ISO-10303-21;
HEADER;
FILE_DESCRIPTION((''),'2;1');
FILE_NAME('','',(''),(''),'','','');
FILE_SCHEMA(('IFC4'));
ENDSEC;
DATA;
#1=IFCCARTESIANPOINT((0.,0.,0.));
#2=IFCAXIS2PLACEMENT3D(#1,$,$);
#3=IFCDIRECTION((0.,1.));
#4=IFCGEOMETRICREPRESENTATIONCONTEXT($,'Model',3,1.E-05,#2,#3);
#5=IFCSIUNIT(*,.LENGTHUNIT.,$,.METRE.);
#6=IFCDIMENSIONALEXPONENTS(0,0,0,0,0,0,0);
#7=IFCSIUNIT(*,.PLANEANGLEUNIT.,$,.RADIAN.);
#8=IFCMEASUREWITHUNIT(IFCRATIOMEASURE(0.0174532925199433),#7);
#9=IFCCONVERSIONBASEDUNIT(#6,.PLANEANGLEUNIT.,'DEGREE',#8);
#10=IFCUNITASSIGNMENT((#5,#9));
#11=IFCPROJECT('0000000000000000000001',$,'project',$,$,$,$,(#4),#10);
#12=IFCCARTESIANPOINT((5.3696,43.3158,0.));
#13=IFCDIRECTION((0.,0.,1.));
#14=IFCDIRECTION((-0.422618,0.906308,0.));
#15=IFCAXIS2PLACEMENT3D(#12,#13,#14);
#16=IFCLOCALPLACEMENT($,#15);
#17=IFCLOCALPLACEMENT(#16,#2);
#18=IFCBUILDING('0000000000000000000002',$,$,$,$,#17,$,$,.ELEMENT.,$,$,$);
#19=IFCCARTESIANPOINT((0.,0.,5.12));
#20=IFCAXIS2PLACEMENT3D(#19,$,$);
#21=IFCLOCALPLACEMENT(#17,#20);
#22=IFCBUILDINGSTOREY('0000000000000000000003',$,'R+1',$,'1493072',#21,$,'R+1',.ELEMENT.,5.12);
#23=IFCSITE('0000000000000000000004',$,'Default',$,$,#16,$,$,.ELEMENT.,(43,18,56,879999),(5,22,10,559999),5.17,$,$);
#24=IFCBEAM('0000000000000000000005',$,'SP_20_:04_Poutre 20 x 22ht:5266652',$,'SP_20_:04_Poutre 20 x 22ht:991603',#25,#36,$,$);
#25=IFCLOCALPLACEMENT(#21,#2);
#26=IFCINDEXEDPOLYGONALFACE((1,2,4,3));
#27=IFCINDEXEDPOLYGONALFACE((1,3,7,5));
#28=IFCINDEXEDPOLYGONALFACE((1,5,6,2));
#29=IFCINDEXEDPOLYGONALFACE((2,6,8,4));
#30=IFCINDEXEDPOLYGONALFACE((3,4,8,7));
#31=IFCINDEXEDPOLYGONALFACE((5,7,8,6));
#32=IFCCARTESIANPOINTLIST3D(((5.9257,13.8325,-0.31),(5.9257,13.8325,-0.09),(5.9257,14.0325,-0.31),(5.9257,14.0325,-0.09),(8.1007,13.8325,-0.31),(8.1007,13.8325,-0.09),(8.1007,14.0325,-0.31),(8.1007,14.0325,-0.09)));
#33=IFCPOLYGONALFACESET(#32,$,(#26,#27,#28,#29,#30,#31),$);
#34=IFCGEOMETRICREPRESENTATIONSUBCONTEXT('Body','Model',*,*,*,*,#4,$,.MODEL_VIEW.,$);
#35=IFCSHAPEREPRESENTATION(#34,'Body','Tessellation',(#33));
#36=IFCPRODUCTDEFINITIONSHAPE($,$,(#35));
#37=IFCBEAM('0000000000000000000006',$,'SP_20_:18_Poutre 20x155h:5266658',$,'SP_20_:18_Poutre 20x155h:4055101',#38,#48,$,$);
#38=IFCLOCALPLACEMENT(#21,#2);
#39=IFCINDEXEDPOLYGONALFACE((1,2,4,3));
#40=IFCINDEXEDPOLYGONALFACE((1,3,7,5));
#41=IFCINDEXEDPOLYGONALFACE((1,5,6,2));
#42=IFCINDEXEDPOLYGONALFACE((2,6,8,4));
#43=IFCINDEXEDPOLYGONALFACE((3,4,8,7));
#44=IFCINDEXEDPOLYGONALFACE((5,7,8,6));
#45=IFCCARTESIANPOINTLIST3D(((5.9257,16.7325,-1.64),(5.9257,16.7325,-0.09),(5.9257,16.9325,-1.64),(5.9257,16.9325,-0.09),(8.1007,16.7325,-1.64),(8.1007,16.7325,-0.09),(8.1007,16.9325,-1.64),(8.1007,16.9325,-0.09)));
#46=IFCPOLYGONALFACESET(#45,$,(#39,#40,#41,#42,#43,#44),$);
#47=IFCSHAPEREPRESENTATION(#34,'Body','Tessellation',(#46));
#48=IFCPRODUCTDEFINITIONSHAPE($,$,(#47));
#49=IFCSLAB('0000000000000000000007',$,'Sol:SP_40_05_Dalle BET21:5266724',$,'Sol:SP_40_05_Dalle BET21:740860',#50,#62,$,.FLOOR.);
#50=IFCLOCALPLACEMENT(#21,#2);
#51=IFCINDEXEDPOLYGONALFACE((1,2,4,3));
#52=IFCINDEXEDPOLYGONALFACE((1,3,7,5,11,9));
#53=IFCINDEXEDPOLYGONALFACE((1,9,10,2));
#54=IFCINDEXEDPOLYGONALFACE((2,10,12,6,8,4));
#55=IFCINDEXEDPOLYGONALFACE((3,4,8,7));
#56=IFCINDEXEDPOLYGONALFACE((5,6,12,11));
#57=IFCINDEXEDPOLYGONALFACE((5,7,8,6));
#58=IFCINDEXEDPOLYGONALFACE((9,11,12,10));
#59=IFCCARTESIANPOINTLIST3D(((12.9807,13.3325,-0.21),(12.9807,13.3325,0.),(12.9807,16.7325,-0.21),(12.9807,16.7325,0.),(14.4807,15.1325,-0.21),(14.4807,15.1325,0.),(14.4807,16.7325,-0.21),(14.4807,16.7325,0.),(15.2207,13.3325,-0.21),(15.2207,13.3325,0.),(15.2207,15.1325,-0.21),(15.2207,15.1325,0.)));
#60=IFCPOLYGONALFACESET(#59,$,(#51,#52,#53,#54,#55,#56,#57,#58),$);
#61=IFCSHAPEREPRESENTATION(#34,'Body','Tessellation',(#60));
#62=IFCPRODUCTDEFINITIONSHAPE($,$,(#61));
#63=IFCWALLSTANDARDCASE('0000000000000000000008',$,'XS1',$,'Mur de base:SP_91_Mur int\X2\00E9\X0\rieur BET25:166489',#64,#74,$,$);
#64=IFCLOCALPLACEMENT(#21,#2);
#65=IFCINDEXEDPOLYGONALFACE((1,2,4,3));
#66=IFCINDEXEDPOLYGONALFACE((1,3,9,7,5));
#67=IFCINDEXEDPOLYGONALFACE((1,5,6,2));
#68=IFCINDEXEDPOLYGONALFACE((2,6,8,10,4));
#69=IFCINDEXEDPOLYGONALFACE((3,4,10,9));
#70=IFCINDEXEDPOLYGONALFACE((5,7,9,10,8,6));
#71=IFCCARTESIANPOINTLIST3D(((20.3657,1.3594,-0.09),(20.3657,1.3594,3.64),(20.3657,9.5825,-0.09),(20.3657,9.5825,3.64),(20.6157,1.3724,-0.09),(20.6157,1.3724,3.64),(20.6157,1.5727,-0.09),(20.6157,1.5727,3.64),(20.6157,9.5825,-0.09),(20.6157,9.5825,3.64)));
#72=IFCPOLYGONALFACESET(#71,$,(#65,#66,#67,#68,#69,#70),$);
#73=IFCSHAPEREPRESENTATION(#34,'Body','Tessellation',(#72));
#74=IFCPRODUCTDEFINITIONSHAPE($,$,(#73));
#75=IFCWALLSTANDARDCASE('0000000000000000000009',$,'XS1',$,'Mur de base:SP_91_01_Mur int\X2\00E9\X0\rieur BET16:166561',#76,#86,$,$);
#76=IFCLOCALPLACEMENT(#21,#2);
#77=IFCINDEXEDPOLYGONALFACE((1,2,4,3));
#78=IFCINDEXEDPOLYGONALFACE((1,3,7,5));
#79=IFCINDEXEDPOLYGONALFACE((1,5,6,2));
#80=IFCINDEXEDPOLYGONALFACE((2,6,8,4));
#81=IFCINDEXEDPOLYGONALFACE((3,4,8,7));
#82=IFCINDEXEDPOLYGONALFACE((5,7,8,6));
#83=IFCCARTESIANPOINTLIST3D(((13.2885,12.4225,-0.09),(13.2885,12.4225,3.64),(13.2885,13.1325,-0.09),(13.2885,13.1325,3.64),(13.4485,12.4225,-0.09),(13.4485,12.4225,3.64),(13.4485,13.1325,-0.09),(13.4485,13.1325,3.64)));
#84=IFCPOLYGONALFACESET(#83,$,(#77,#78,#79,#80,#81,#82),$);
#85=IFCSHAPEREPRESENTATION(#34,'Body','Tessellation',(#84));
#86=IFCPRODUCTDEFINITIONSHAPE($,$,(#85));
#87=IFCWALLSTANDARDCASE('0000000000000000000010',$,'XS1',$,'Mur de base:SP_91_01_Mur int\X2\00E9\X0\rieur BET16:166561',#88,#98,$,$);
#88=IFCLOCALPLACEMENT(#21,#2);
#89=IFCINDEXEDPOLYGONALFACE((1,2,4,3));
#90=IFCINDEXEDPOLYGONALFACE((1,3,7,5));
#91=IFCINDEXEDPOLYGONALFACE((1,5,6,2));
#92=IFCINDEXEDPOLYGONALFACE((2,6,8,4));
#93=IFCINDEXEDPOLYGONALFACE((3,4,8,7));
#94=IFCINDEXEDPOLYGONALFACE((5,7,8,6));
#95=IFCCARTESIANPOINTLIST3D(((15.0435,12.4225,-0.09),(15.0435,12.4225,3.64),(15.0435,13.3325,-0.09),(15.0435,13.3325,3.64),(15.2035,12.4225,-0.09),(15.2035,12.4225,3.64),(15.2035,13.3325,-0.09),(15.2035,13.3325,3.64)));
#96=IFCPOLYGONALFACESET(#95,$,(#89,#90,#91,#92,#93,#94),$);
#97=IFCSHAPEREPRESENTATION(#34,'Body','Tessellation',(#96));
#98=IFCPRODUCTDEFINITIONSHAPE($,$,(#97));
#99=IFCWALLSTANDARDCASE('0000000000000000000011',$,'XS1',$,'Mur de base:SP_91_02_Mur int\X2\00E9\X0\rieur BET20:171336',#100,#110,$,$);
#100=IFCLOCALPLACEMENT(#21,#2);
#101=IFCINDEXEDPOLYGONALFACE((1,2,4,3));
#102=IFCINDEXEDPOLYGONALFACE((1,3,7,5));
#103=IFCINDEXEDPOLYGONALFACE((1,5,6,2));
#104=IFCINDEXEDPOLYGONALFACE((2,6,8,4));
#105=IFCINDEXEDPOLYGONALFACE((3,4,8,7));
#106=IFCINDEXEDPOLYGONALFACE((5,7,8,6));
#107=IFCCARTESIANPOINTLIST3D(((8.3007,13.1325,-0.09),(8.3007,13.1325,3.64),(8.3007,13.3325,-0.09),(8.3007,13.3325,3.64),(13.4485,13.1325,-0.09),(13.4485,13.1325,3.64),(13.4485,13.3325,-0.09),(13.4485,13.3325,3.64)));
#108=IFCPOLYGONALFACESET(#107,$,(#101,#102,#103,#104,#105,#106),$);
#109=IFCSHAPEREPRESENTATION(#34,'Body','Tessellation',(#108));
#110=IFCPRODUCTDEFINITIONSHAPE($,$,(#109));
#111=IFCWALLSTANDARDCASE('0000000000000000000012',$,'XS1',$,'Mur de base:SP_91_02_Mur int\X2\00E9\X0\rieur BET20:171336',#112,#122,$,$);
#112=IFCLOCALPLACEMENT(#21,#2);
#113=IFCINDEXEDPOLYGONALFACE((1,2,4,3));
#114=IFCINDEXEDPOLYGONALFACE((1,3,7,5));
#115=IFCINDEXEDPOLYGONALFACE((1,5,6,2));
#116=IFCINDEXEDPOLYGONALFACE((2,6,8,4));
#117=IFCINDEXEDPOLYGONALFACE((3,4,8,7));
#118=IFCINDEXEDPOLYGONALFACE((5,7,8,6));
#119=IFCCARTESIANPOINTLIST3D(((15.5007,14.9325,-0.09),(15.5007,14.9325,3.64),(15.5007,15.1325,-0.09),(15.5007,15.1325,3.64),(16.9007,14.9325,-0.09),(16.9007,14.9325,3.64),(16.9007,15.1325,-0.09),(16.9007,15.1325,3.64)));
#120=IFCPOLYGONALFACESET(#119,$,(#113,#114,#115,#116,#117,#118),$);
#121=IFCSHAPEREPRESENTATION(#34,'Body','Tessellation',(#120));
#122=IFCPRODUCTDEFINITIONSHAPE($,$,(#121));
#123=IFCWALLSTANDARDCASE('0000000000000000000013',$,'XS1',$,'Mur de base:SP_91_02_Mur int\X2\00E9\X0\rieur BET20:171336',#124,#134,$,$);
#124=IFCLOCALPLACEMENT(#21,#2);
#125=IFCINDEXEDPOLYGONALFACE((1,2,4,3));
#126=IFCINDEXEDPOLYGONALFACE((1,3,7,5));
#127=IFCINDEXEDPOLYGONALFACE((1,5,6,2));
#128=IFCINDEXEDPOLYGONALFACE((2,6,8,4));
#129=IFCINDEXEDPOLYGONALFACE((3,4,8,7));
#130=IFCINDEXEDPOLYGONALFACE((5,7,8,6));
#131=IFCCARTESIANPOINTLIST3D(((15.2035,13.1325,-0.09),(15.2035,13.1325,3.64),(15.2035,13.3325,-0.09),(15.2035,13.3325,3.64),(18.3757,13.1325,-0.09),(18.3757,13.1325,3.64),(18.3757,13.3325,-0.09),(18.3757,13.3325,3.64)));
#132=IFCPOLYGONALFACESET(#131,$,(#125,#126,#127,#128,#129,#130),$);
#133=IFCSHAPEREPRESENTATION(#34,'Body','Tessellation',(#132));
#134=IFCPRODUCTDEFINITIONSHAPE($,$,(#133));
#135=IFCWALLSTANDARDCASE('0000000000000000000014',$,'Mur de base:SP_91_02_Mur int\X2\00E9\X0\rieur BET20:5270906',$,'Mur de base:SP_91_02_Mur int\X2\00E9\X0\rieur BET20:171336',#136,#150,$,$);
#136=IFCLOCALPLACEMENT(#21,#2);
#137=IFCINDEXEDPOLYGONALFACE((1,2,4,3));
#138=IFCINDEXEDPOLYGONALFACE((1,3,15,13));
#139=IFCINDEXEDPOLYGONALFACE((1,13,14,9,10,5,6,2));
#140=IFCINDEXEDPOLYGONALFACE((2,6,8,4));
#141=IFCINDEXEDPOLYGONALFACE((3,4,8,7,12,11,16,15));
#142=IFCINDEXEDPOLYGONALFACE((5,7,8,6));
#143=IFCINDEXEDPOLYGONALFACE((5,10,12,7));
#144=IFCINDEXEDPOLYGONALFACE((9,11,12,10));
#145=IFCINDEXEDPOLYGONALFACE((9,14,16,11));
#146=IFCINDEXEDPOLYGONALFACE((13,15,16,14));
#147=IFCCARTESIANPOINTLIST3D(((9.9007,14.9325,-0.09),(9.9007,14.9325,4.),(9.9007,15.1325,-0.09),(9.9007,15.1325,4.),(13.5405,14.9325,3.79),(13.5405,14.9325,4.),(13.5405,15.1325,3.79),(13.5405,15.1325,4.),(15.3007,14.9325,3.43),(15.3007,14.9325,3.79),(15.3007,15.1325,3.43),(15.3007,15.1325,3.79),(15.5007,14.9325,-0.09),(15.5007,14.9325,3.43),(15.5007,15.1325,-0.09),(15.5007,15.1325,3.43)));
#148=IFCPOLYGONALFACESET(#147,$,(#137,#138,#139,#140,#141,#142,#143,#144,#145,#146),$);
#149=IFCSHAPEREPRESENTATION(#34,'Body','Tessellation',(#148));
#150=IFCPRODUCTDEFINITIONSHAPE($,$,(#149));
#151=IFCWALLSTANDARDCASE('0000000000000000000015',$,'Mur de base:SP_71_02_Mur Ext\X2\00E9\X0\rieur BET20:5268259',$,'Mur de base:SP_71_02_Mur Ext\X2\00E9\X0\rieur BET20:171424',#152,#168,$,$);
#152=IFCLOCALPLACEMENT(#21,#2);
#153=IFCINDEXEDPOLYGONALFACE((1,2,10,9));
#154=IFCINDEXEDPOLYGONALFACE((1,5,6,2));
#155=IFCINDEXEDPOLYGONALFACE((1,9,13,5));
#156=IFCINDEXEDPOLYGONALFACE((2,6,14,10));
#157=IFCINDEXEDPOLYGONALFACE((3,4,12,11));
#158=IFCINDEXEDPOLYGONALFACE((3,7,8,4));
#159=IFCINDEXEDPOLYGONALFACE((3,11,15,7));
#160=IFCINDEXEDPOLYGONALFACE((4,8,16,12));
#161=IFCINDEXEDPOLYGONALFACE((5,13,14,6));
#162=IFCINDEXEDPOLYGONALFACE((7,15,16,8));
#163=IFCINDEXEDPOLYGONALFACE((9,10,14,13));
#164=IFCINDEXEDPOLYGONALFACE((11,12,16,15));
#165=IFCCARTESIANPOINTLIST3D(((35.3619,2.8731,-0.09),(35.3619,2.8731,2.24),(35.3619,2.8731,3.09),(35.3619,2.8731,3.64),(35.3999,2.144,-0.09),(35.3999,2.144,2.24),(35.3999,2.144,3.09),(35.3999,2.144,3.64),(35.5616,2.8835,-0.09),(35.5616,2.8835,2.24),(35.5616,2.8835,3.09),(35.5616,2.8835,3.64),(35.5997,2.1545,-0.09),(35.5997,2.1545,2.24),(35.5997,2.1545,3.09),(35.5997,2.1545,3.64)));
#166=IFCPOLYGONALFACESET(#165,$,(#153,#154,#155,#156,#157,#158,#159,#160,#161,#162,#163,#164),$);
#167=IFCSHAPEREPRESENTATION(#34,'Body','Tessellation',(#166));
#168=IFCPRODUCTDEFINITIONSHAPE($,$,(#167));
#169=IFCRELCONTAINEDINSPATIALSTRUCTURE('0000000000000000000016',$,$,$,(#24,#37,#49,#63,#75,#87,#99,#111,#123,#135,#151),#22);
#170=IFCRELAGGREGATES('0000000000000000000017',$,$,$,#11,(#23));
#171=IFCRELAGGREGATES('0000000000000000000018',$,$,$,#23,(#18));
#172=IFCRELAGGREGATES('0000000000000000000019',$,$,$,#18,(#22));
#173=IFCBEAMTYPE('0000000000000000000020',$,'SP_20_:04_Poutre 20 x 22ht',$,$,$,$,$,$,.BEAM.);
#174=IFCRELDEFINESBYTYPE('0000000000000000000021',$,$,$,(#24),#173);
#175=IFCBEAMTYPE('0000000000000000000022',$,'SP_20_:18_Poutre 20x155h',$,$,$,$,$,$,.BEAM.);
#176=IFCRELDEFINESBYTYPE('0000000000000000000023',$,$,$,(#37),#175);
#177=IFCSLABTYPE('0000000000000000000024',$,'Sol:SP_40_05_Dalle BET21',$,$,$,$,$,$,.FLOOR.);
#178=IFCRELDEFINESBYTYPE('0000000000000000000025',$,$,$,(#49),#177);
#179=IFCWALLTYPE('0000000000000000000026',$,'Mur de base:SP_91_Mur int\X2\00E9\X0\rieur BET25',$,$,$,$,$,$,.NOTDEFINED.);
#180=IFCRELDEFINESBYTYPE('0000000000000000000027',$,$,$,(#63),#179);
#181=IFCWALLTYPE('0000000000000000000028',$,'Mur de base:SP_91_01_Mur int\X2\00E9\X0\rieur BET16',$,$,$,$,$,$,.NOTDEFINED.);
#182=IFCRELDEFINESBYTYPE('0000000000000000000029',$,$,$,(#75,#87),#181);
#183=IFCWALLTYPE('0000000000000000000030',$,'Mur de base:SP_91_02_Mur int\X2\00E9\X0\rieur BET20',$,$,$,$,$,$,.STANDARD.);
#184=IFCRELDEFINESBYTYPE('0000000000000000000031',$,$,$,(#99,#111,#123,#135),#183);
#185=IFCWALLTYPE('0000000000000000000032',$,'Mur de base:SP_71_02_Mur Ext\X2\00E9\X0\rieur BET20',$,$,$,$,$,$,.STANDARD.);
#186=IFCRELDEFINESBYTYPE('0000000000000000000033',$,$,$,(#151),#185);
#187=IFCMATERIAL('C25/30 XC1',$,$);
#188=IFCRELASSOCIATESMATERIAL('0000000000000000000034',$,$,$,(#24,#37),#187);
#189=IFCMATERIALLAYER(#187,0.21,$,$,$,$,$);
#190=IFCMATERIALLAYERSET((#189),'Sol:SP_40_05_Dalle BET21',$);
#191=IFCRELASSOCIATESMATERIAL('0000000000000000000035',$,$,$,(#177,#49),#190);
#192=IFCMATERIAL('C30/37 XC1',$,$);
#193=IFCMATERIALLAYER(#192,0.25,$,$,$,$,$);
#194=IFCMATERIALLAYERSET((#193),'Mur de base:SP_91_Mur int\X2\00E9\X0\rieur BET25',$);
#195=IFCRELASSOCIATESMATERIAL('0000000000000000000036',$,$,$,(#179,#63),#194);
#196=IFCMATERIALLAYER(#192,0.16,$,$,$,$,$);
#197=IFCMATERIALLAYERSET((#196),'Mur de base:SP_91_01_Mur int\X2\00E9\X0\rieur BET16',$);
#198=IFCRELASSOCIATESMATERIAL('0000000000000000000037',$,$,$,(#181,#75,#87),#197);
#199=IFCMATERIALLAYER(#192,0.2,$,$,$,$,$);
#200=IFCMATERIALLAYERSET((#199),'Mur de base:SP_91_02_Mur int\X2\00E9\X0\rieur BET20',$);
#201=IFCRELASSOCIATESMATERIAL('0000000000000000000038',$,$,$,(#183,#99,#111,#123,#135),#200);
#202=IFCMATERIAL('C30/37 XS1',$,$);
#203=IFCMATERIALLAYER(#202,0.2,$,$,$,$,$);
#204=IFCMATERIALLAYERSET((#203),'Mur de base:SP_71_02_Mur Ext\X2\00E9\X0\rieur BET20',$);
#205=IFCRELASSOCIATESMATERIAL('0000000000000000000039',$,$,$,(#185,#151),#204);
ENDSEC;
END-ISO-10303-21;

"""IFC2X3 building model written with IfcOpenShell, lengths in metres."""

from ifc_helpers import new_model, entity, si_unit, converted_unit, direction, frame, frame_2d, origin, place, context, subcontext, project, spatial, polyline, rectangle, outline, extrude, clip, bounded_halfspace, material, layer, layer_set, layer_usage, type_object, element, save


model = new_model("IFC2X3")

# Units and contexts
model_context = context("Model", 3, precision=1e-05, world=origin(), true_north=direction((0.0, 1.0)))
body_context = subcontext(model_context, "Body", "Model", "MODEL_VIEW")
ifc_project = project(units=[si_unit("LENGTHUNIT", "METRE"), converted_unit("PLANEANGLEUNIT", "DEGREE", entity("IfcRatioMeasure", 0.0174532925199433), si_unit("PLANEANGLEUNIT", "RADIAN"), dimensions=[0, 0, 0, 0, 0, 0, 0])], contexts=[model_context])

# Site, building, storey
site_placement = place(None, frame((5.3696, 43.3158, 0.0), z_axis=(0.0, 0.0, 1.0), x_axis=(-0.422618, 0.906308, 0.0)))
site = spatial("IfcSite", under=ifc_project, at=site_placement, Name="Default", CompositionType="ELEMENT", RefLatitude=(43, 18, 56, 879999), RefLongitude=(5, 22, 10, 559999), RefElevation=5.17)
building_placement = place(site_placement, origin())
building = spatial("IfcBuilding", under=site, at=building_placement, CompositionType="ELEMENT")
storey_placement = place(building_placement, frame((0.0, 0.0, 5.12)))
storey = spatial("IfcBuildingStorey", under=building, at=storey_placement, Name="R+1", ObjectType="1493072", LongName="R+1", CompositionType="ELEMENT", Elevation=5.12)

# Beams
ifc_material_1 = material(Name="C25/30 XC1")
beam_type_1 = type_object("IfcBeamType", Name="SP_20_:04_Poutre 20 x 22ht", PredefinedType="BEAM")
beam_1_placement = place(storey_placement, frame((8.2007, 13.9325, -0.09), z_axis=(0.0, 0.0, 1.0), x_axis=(-1.0, 0.0, 0.0)))
element("IfcBeam", 1, at=beam_1_placement, inside=storey, type_object=beam_type_1, material=ifc_material_1, Name="SP_20_:04_Poutre 20 x 22ht:5266652", ObjectType="SP_20_:04_Poutre 20 x 22ht:991603", context=body_context, shape_type="SweptSolid", body=[
    extrude(rectangle(XDim=0.22, YDim=0.2, at=frame_2d((0.0, 0.0), x_axis=(1.0, 0.0))), frame((0.1, 0.0, -0.11), z_axis=(1.0, 0.0, 0.0), x_axis=(0.0, 0.0, -1.0)), (0.0, 0.0, 1.0), 2.175),
])
beam_type_2 = type_object("IfcBeamType", Name="SP_20_:18_Poutre 20x155h", PredefinedType="BEAM")
beam_2_placement = place(storey_placement, frame((8.2007, 16.8325, -0.09), z_axis=(0.0, 0.0, 1.0), x_axis=(-1.0, 0.0, 0.0)))
element("IfcBeam", 2, at=beam_2_placement, inside=storey, type_object=beam_type_2, material=ifc_material_1, Name="SP_20_:18_Poutre 20x155h:5266658", ObjectType="SP_20_:18_Poutre 20x155h:4055101", context=body_context, shape_type="SweptSolid", body=[
    extrude(rectangle(XDim=1.55, YDim=0.2, at=frame_2d((0.0, 0.0), x_axis=(1.0, 0.0))), frame((0.1, 0.0, -0.775), z_axis=(1.0, 0.0, 0.0), x_axis=(0.0, 0.0, -1.0)), (0.0, 0.0, 1.0), 2.175),
])

# Slab
ifc_layer_1 = layer(ifc_material_1, 0.21)
ifc_layer_set_1 = layer_set([ifc_layer_1], Name="Sol:SP_40_05_Dalle BET21")
ifc_layer_usage_1 = layer_usage(ifc_layer_set_1, "AXIS3", "POSITIVE", 0.0)
slab_type = type_object("IfcSlabType", Name="Sol:SP_40_05_Dalle BET21", PredefinedType="FLOOR", material=ifc_layer_set_1)
slab_placement = place(storey_placement, frame((12.9807, 13.3325, -0.21)))
element("IfcSlab", 3, at=slab_placement, inside=storey, type_object=slab_type, material=ifc_layer_usage_1, Name="Sol:SP_40_05_Dalle BET21:5266724", ObjectType="Sol:SP_40_05_Dalle BET21:740860", PredefinedType="FLOOR", context=body_context, shape_type="SweptSolid", body=[
    extrude(outline(polyline([(-1.12, 0.1), (-1.12, -1.7), (1.12, -1.7), (1.12, 1.7), (-0.38, 1.7), (-0.38, 0.1), (-1.12, 0.1)])), frame((1.12, 1.7, 0.21), z_axis=(0.0, 0.0, -1.0), x_axis=(-1.0, 0.0, 0.0)), (0.0, 0.0, 1.0), 0.21),
])

# Shared definitions
ifc_material_2 = material(Name="C30/37 XC1")
ifc_layer_2 = layer(ifc_material_2, 0.25)
ifc_layer_set_2 = layer_set([ifc_layer_2], Name="Mur de base:SP_91_Mur intérieur BET25")
wall_type_1 = type_object("IfcWallType", Name="Mur de base:SP_91_Mur intérieur BET25", PredefinedType="NOTDEFINED", material=ifc_layer_set_2)

# Wall
ifc_layer_usage_2 = layer_usage(ifc_layer_set_2, "AXIS2", "NEGATIVE", 0.125)
wall_1_placement = place(storey_placement, frame((20.4907, 9.5825, -0.09), z_axis=(0.0, 0.0, 1.0), x_axis=(0.0, -1.0, 0.0)))
element("IfcWallStandardCase", 4, at=wall_1_placement, inside=storey, type_object=wall_type_1, material=ifc_layer_usage_2, Name="XS1", ObjectType="Mur de base:SP_91_Mur intérieur BET25:166489", context=body_context, shape_type="SweptSolid", body=[
    extrude(outline(polyline([(8.2231, -0.125), (8.2101, 0.125), (8.0098, 0.125), (0.0, 0.125), (0.0, -0.125), (8.2231, -0.125)])), origin(), (0.0, 0.0, 1.0), 3.73),
])

# Walls
ifc_layer_3 = layer(ifc_material_2, 0.16)
ifc_layer_set_3 = layer_set([ifc_layer_3], Name="Mur de base:SP_91_01_Mur intérieur BET16")
ifc_layer_usage_3 = layer_usage(ifc_layer_set_3, "AXIS2", "NEGATIVE", 0.08)
wall_type_2 = type_object("IfcWallType", Name="Mur de base:SP_91_01_Mur intérieur BET16", PredefinedType="NOTDEFINED", material=ifc_layer_set_3)
wall_2_placement = place(storey_placement, frame((13.3685, 13.1325, -0.09), z_axis=(0.0, 0.0, 1.0), x_axis=(0.0, -1.0, 0.0)))
element("IfcWallStandardCase", 5, at=wall_2_placement, inside=storey, type_object=wall_type_2, material=ifc_layer_usage_3, Name="XS1", ObjectType="Mur de base:SP_91_01_Mur intérieur BET16:166561", context=body_context, shape_type="SweptSolid", body=[
    extrude(rectangle(XDim=0.71, YDim=0.16, at=frame_2d((0.355, 0.0), x_axis=(-1.0, 0.0))), origin(), (0.0, 0.0, 1.0), 3.73),
])
ifc_layer_usage_4 = layer_usage(ifc_layer_set_3, "AXIS2", "NEGATIVE", 0.08)
wall_3_placement = place(storey_placement, frame((15.1235, 12.4225, -0.09), z_axis=(0.0, 0.0, 1.0), x_axis=(0.0, 1.0, 0.0)))
element("IfcWallStandardCase", 6, at=wall_3_placement, inside=storey, type_object=wall_type_2, material=ifc_layer_usage_4, Name="XS1", ObjectType="Mur de base:SP_91_01_Mur intérieur BET16:166561", context=body_context, shape_type="SweptSolid", body=[
    extrude(rectangle(XDim=0.91, YDim=0.16, at=frame_2d((0.455, 0.0), x_axis=(-1.0, 0.0))), origin(), (0.0, 0.0, 1.0), 3.73),
])
ifc_layer_4 = layer(ifc_material_2, 0.2)
ifc_layer_set_4 = layer_set([ifc_layer_4], Name="Mur de base:SP_91_02_Mur intérieur BET20")
ifc_layer_usage_5 = layer_usage(ifc_layer_set_4, "AXIS2", "NEGATIVE", 0.1)
wall_type_3 = type_object("IfcWallType", Name="Mur de base:SP_91_02_Mur intérieur BET20", PredefinedType="STANDARD", material=ifc_layer_set_4)
wall_4_placement = place(storey_placement, frame((8.3007, 13.2325, -0.09)))
element("IfcWallStandardCase", 7, at=wall_4_placement, inside=storey, type_object=wall_type_3, material=ifc_layer_usage_5, Name="XS1", ObjectType="Mur de base:SP_91_02_Mur intérieur BET20:171336", context=body_context, shape_type="SweptSolid", body=[
    extrude(rectangle(XDim=5.1478, YDim=0.2, at=frame_2d((2.5739, 0.0), x_axis=(-1.0, 0.0))), origin(), (0.0, 0.0, 1.0), 3.73),
])
ifc_layer_usage_6 = layer_usage(ifc_layer_set_4, "AXIS2", "NEGATIVE", 0.1)
wall_5_placement = place(storey_placement, frame((16.9007, 15.0325, -0.09), z_axis=(0.0, 0.0, 1.0), x_axis=(-1.0, 0.0, 0.0)))
element("IfcWallStandardCase", 8, at=wall_5_placement, inside=storey, type_object=wall_type_3, material=ifc_layer_usage_6, Name="XS1", ObjectType="Mur de base:SP_91_02_Mur intérieur BET20:171336", context=body_context, shape_type="SweptSolid", body=[
    extrude(rectangle(XDim=1.4, YDim=0.2, at=frame_2d((0.7, 0.0), x_axis=(-1.0, 0.0))), origin(), (0.0, 0.0, 1.0), 3.73),
])
ifc_layer_usage_7 = layer_usage(ifc_layer_set_4, "AXIS2", "NEGATIVE", 0.1)
wall_6_placement = place(storey_placement, frame((18.3757, 13.2325, -0.09), z_axis=(0.0, 0.0, 1.0), x_axis=(-1.0, 0.0, 0.0)))
element("IfcWallStandardCase", 9, at=wall_6_placement, inside=storey, type_object=wall_type_3, material=ifc_layer_usage_7, Name="XS1", ObjectType="Mur de base:SP_91_02_Mur intérieur BET20:171336", context=body_context, shape_type="SweptSolid", body=[
    extrude(rectangle(XDim=3.1722, YDim=0.2, at=frame_2d((1.5861, 0.0), x_axis=(-1.0, 0.0))), origin(), (0.0, 0.0, 1.0), 3.73),
])
ifc_layer_usage_8 = layer_usage(ifc_layer_set_4, "AXIS2", "NEGATIVE", 0.1)
wall_7_placement = place(storey_placement, frame((15.5007, 15.0325, -0.09), z_axis=(0.0, 0.0, 1.0), x_axis=(-1.0, 0.0, 0.0)))
element("IfcWallStandardCase", 10, at=wall_7_placement, inside=storey, type_object=wall_type_3, material=ifc_layer_usage_8, Name="Mur de base:SP_91_02_Mur intérieur BET20:5270906", ObjectType="Mur de base:SP_91_02_Mur intérieur BET20:171336", context=body_context, shape_type="Clipping", body=[
    clip(clip(clip(extrude(rectangle(XDim=5.6, YDim=0.2, at=frame_2d((2.8, 0.0), x_axis=(-1.0, 0.0))), origin(), (0.0, 0.0, 1.0), 4.09), bounded_halfspace(frame((1.9601, -0.1, 3.88), z_axis=(0.0, 0.0, -1.0), x_axis=(1.0, 0.0, 0.0)), True, frame((1.9601, -0.1, 3.88), z_axis=(0.0, 0.0, -1.0), x_axis=(1.0, 0.0, 0.0)), polyline([(0.0, 0.0), (-1.7601, 0.0), (-1.7601, -0.2), (0.0, -0.2), (0.0, 0.0)]))), bounded_halfspace(frame((1.9601, 0.1, 3.88), z_axis=(1.0, 0.0, 0.0), x_axis=(0.0, 0.0, 1.0)), True, frame((1.9601, 0.1, 3.88), z_axis=(1.0, 0.0, 0.0), x_axis=(0.0, 0.0, 1.0)), polyline([(0.0, 0.0), (0.21, 0.0), (0.21, 0.2), (0.0, 0.2), (0.0, 0.0)]))), bounded_halfspace(frame((0.2, -0.1, 3.52), z_axis=(0.0, 0.0, -1.0), x_axis=(1.0, 0.0, 0.0)), True, frame((0.2, -0.1, 3.52), z_axis=(0.0, 0.0, -1.0), x_axis=(1.0, 0.0, 0.0)), polyline([(0.0, 0.0), (-0.2, 0.0), (-0.2, -0.2), (0.0, -0.2), (0.0, 0.0)]))),
])

# Wall, opening
ifc_material_3 = material(Name="C30/37 XS1")
ifc_layer_5 = layer(ifc_material_3, 0.2)
ifc_layer_set_5 = layer_set([ifc_layer_5], Name="Mur de base:SP_71_02_Mur Extérieur BET20")
wall_type_4 = type_object("IfcWallType", Name="Mur de base:SP_71_02_Mur Extérieur BET20", PredefinedType="STANDARD", material=ifc_layer_set_5)
ifc_layer_usage_9 = layer_usage(ifc_layer_set_5, "AXIS2", "NEGATIVE", 0.1)
wall_8_placement = place(storey_placement, frame((35.4618, 2.8783, -0.09), z_axis=(0.0, 0.0, 1.0), x_axis=(0.05212, -0.998641, 0.0)))
wall_8 = element("IfcWallStandardCase", 11, at=wall_8_placement, inside=storey, type_object=wall_type_4, material=ifc_layer_usage_9, Name="Mur de base:SP_71_02_Mur Extérieur BET20:5268259", ObjectType="Mur de base:SP_71_02_Mur Extérieur BET20:171424", context=body_context, shape_type="SweptSolid", body=[
    extrude(rectangle(XDim=0.73, YDim=0.2, at=frame_2d((0.365, 0.0), x_axis=(-1.0, 0.0))), origin(), (0.0, 0.0, 1.0), 3.73),
])
opening_1_placement = place(storey_placement, frame((35.4618, 2.8783, -0.09), z_axis=(0.0, 0.0, 1.0), x_axis=(0.05212, -0.998641, 0.0)))
element("IfcOpeningElement", 12, at=opening_1_placement, cuts=wall_8, ObjectType="Opening", context=body_context, shape_type="SweptSolid", body=[
    extrude(rectangle(XDim=0.73, YDim=0.2, at=frame_2d((0.0, 0.0), x_axis=(1.0, 0.0))), frame((0.365, 0.0, 2.33)), (0.0, 0.0, 1.0), 0.85),
])

save(model, "model.ifc")
